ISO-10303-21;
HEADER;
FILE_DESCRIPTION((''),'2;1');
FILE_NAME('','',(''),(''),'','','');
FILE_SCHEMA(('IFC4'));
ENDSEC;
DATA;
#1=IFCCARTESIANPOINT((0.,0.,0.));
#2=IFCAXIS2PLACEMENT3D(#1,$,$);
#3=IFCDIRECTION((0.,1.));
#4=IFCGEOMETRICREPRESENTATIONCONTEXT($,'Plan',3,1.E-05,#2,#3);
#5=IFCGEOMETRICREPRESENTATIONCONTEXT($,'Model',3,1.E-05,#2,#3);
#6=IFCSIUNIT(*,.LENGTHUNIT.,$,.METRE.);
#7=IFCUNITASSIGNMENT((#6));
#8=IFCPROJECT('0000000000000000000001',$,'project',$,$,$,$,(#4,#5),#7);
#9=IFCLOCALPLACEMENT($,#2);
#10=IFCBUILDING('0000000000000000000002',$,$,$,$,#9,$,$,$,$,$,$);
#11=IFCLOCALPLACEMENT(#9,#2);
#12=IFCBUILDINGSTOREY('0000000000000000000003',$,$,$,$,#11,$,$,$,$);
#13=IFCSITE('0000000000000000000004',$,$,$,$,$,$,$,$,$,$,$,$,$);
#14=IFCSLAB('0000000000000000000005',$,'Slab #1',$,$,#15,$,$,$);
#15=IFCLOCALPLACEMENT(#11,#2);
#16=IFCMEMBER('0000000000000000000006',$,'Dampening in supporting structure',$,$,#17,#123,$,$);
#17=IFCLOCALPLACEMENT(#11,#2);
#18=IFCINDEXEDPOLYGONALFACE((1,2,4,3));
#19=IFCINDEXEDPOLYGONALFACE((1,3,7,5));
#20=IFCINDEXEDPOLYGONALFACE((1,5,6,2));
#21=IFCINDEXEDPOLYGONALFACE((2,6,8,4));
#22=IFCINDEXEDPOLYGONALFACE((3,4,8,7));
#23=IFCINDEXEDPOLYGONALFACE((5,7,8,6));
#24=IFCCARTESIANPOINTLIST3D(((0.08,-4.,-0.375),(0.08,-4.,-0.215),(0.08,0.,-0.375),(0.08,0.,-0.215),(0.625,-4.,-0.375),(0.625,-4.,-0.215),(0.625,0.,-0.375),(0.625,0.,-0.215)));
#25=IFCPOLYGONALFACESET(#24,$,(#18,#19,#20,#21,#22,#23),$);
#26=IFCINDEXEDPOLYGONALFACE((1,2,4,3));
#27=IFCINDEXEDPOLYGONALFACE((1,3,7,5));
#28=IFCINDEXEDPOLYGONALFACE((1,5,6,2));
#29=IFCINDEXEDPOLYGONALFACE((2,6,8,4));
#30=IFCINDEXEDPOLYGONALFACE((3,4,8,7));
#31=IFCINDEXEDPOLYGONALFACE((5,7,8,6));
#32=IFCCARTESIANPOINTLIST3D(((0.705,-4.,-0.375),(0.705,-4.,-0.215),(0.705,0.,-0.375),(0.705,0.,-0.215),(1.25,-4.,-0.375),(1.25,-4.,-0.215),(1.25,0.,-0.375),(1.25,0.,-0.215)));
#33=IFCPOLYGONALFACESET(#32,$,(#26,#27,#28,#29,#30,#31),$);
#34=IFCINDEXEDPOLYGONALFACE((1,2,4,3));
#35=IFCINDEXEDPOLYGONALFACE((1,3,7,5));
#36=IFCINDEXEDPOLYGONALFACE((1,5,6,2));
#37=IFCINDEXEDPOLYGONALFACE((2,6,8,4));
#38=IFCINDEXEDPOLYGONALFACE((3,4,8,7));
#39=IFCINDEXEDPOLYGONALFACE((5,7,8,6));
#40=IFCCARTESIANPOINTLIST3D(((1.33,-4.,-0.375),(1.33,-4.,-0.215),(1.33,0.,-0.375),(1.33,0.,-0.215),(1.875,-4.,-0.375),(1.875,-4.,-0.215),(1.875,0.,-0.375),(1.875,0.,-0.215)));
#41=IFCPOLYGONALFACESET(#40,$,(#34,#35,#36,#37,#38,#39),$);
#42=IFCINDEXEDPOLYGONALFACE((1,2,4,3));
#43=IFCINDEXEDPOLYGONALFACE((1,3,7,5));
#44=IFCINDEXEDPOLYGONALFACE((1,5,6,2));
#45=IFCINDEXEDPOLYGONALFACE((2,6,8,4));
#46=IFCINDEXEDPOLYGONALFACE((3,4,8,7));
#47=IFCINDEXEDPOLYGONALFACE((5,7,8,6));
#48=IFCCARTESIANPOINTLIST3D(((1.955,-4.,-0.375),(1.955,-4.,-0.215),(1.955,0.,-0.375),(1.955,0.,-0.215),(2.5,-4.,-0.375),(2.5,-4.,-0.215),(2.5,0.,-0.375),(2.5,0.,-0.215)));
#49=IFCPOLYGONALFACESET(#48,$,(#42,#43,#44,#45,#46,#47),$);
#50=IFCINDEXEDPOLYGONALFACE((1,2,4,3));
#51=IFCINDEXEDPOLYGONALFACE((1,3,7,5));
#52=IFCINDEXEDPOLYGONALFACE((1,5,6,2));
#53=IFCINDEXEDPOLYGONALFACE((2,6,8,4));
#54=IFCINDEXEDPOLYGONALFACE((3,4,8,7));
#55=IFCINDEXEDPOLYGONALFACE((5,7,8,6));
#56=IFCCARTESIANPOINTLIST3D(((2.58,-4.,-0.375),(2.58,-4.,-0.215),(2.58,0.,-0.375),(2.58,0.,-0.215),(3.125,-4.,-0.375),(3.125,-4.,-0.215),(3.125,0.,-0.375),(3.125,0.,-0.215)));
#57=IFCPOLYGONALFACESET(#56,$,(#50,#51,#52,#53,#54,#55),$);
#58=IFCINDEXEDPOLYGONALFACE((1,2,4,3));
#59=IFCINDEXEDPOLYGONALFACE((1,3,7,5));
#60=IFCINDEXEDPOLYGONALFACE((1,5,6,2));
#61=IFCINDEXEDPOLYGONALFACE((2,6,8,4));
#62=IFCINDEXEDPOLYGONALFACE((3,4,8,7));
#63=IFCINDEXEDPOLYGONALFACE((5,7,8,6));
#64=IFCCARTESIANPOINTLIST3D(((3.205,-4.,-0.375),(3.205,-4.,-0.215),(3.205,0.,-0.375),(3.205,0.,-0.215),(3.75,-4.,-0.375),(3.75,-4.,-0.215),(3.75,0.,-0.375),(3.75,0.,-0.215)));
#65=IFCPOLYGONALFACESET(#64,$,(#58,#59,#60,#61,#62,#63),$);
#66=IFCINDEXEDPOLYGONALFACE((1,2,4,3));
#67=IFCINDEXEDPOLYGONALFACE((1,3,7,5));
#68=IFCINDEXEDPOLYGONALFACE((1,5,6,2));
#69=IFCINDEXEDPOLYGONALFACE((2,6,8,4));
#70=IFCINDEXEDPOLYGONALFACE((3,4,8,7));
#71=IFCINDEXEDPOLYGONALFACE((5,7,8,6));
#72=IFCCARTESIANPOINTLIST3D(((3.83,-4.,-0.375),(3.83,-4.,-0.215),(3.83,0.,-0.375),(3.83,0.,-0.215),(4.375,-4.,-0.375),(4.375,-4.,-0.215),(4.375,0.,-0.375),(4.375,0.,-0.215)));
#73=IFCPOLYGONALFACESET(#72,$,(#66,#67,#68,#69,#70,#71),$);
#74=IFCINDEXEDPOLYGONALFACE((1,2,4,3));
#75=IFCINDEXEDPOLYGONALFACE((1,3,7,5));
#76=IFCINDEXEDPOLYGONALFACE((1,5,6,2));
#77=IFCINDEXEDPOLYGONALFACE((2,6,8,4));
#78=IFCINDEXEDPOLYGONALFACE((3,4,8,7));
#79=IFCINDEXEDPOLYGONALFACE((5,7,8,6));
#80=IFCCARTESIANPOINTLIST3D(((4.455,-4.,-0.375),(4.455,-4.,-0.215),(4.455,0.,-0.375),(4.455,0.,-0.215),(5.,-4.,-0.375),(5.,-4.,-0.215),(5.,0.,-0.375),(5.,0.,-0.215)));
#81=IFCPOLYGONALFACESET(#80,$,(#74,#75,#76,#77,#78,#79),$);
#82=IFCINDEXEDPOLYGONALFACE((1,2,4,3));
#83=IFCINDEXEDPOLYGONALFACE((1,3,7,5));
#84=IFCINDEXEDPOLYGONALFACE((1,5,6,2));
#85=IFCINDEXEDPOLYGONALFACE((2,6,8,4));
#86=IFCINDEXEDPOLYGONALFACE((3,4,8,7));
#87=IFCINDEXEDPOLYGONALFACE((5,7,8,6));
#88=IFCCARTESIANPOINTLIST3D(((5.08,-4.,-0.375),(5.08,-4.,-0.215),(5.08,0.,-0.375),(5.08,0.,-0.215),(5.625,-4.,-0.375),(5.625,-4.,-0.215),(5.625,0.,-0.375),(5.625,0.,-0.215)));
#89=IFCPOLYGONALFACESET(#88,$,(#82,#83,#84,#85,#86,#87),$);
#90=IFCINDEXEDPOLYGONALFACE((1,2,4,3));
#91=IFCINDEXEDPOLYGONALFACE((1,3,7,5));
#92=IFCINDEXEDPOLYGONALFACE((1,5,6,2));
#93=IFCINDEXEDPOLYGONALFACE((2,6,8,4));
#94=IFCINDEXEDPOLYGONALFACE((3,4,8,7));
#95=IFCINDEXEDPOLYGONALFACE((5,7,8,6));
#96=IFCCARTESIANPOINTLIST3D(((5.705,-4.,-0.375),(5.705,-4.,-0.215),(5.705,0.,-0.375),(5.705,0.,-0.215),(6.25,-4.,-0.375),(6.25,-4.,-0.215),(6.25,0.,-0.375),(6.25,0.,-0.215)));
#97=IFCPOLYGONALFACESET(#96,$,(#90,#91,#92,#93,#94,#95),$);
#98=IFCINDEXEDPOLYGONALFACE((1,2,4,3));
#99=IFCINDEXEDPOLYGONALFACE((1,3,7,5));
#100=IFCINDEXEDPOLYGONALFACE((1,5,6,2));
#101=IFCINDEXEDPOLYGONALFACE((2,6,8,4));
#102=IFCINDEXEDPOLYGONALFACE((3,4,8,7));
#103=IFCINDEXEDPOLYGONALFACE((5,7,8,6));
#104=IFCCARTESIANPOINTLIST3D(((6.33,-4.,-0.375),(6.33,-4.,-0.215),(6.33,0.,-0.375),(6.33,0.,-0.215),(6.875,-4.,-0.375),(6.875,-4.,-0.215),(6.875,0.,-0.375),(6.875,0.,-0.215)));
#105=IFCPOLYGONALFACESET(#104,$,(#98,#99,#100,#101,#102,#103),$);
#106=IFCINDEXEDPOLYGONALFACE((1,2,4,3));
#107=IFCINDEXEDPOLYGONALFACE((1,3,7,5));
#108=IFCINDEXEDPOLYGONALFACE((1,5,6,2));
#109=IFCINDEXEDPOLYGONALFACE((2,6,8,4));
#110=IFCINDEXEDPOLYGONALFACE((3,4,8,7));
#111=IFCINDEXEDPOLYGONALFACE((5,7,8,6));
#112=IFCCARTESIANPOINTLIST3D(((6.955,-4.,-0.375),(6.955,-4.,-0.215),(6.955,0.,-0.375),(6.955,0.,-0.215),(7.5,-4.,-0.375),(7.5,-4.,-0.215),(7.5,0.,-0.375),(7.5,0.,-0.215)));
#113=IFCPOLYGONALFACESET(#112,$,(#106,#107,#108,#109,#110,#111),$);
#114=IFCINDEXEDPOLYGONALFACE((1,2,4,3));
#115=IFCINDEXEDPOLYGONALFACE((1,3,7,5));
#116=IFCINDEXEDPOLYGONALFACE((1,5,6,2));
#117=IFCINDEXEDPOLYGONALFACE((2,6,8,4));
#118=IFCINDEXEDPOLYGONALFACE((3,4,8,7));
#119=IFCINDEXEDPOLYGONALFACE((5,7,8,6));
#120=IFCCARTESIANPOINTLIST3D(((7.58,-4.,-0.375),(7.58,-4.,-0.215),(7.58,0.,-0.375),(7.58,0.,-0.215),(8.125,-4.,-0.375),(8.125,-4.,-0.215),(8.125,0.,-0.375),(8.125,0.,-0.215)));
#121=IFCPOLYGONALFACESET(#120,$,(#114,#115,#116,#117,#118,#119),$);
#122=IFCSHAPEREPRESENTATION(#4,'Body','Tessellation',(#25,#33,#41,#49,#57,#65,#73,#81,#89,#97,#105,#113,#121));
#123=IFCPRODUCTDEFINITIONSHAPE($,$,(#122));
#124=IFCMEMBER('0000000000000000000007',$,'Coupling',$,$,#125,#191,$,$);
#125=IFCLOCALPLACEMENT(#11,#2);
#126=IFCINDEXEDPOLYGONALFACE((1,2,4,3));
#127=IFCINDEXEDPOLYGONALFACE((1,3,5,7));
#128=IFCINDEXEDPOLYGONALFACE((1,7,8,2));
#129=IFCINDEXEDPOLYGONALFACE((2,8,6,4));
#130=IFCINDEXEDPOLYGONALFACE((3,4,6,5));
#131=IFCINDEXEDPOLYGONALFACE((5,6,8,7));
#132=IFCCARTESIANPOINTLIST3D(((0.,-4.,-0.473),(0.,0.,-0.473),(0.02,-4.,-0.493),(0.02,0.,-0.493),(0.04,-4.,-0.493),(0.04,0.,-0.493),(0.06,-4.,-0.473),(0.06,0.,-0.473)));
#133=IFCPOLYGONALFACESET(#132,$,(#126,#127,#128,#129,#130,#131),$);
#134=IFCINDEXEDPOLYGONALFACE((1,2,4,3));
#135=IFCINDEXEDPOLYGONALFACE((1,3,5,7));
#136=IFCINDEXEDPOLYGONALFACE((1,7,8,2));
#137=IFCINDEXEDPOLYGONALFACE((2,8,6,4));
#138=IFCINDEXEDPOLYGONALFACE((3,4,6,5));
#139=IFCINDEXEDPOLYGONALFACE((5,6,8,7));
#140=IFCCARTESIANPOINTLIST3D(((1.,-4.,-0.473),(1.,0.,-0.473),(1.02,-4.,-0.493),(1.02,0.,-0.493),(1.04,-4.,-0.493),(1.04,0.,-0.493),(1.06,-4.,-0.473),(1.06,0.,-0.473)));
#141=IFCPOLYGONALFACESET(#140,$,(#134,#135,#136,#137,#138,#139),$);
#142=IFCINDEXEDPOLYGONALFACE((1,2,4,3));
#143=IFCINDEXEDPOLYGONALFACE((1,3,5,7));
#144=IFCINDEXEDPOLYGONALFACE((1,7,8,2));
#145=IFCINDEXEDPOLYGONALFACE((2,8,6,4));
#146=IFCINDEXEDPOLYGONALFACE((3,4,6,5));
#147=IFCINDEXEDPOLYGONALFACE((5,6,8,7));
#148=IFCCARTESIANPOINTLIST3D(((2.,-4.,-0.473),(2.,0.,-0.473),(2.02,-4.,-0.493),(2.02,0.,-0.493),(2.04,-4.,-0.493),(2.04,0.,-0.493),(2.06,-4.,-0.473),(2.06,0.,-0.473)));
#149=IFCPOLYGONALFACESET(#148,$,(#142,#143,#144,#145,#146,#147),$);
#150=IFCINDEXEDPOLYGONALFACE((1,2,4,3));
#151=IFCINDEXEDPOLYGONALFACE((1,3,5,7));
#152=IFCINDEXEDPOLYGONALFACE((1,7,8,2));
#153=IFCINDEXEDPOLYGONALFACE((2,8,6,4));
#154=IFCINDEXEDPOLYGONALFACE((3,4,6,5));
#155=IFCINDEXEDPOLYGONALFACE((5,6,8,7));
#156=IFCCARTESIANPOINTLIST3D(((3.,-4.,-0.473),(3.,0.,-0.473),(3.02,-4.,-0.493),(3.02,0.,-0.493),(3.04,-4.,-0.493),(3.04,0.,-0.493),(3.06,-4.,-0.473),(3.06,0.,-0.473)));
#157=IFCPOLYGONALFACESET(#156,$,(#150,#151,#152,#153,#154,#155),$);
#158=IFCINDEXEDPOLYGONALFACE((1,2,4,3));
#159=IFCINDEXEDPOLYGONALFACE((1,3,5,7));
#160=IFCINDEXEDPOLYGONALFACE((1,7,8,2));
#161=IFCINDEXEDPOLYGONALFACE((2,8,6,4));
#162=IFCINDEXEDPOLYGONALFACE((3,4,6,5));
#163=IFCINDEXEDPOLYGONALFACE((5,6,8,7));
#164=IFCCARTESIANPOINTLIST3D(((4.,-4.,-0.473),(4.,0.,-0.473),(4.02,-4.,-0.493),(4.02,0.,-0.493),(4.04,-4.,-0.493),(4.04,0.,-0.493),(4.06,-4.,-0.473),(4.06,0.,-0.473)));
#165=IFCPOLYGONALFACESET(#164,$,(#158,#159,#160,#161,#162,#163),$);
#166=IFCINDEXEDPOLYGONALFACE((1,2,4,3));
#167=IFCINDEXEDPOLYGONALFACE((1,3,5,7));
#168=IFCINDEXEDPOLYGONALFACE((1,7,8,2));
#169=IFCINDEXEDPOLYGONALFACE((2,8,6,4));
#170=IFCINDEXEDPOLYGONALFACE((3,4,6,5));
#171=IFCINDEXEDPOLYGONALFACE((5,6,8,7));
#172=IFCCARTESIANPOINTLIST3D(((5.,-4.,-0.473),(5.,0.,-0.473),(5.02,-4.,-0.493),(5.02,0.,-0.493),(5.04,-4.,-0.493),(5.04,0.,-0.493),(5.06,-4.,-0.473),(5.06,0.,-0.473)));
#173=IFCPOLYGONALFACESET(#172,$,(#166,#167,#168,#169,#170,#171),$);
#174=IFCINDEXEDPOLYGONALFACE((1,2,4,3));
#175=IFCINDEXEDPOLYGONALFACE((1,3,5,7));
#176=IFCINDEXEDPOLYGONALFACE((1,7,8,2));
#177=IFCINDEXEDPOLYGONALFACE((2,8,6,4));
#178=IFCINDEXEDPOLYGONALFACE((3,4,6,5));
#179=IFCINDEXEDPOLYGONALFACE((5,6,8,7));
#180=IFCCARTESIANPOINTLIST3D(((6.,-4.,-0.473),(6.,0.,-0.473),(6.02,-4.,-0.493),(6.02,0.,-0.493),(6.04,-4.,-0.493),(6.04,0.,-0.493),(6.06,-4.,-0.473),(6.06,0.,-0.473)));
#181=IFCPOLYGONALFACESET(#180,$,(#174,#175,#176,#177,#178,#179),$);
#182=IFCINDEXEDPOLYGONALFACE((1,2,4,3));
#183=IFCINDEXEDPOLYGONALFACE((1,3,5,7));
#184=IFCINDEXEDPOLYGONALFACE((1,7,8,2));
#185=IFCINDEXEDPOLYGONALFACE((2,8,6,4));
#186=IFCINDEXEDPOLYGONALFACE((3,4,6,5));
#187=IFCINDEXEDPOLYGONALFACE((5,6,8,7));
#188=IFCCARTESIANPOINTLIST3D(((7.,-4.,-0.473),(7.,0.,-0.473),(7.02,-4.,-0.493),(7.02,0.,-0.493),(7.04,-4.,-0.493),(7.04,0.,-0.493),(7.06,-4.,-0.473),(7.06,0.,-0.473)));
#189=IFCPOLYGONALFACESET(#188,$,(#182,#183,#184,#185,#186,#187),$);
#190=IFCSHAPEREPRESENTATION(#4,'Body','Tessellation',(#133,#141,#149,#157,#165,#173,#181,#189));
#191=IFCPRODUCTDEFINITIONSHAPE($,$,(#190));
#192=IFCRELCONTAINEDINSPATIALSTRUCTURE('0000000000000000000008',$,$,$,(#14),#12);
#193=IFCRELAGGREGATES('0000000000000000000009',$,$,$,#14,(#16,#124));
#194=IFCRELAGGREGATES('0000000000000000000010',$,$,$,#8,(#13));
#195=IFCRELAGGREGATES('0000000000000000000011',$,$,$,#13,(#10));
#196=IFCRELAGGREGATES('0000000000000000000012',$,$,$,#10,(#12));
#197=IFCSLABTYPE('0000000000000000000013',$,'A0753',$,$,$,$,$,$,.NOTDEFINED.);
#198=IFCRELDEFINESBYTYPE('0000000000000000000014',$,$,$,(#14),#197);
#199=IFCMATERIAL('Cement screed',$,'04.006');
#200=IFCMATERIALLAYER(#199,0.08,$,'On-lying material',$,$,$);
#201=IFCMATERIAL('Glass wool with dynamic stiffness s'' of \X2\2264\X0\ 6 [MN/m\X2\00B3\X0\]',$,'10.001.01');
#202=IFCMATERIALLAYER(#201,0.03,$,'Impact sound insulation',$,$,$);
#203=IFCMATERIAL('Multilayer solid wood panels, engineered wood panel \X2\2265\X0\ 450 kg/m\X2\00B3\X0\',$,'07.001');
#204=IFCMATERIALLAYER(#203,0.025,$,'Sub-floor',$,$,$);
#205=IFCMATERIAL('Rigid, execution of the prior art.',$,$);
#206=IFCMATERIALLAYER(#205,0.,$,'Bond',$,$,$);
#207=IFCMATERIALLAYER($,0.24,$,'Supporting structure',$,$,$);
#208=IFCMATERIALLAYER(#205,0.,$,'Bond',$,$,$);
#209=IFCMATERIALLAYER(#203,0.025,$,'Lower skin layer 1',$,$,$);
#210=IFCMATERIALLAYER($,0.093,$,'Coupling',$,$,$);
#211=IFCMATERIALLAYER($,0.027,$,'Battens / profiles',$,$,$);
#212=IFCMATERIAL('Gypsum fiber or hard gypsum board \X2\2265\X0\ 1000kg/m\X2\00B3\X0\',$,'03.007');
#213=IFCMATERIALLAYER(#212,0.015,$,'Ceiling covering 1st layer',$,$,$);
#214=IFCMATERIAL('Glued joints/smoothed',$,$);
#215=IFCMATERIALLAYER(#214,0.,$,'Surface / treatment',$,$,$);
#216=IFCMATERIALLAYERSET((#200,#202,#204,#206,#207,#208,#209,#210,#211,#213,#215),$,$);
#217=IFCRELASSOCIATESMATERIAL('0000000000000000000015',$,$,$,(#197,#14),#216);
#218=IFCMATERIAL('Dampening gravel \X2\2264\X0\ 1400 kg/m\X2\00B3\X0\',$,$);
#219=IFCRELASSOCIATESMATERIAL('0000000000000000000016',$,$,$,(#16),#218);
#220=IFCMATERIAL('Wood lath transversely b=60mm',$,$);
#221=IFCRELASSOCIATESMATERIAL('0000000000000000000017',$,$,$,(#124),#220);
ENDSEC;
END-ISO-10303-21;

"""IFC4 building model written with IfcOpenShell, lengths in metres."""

from ifc_helpers import new_model, si_unit, direction, frame, frame_2d, origin, place, context, project, spatial, polyline, rectangle, outline, extrude, material, layer, layer_set, type_object, element, aggregate, save


model = new_model("IFC4")

# Units and contexts
plan_context = context("Plan", 3, precision=1e-05, world=origin(), true_north=direction((0.0, 1.0)))
model_context = context("Model", 3, precision=1e-05, world=origin(), true_north=direction((0.0, 1.0)))
ifc_project = project(units=[si_unit("LENGTHUNIT", "METRE")], contexts=[plan_context, model_context])

# Site, building, storey
site = spatial("IfcSite", under=ifc_project)
building_placement = place(None, origin())
building = spatial("IfcBuilding", under=site, at=building_placement)
storey_placement = place(building_placement, origin())
storey = spatial("IfcBuildingStorey", under=building, at=storey_placement)

# Slab, members
ifc_material_1 = material(Name="Cement screed", Category="04.006")
ifc_layer_1 = layer(ifc_material_1, 0.08, Name="On-lying material")
ifc_material_2 = material(Name="Glass wool with dynamic stiffness s' of ≤ 6 [MN/m³]", Category="10.001.01")
ifc_layer_2 = layer(ifc_material_2, 0.03, Name="Impact sound insulation")
ifc_material_3 = material(Name="Multilayer solid wood panels, engineered wood panel ≥ 450 kg/m³", Category="07.001")
ifc_layer_3 = layer(ifc_material_3, 0.025, Name="Sub-floor")
ifc_material_4 = material(Name="Rigid, execution of the prior art.")
ifc_layer_4 = layer(ifc_material_4, 0.0, Name="Bond")
ifc_layer_5 = layer(None, 0.24, Name="Supporting structure")
ifc_layer_6 = layer(ifc_material_4, 0.0, Name="Bond")
ifc_layer_7 = layer(ifc_material_3, 0.025, Name="Lower skin layer 1")
ifc_layer_8 = layer(None, 0.093, Name="Coupling")
ifc_layer_9 = layer(None, 0.027, Name="Battens / profiles")
ifc_material_5 = material(Name="Gypsum fiber or hard gypsum board ≥ 1000kg/m³", Category="03.007")
ifc_layer_10 = layer(ifc_material_5, 0.015, Name="Ceiling covering 1st layer")
ifc_material_6 = material(Name="Glued joints/smoothed")
ifc_layer_11 = layer(ifc_material_6, 0.0, Name="Surface / treatment")
ifc_layer_set = layer_set([ifc_layer_1, ifc_layer_2, ifc_layer_3, ifc_layer_4, ifc_layer_5, ifc_layer_6, ifc_layer_7, ifc_layer_8, ifc_layer_9, ifc_layer_10, ifc_layer_11])
slab_type = type_object("IfcSlabType", Name="A0753", PredefinedType="NOTDEFINED", material=ifc_layer_set)
slab_placement = place(None, frame((0.0, 0.0, 0.0), z_axis=(0.0, 0.0, -1.0), x_axis=(1.0, 0.0, 0.0)))
slab = element("IfcSlab", 1, at=slab_placement, inside=storey, type_object=slab_type, material=ifc_layer_set, Name="Slab #1")
ifc_material_7 = material(Name="Dampening gravel ≤ 1400 kg/m³")
member_1_placement = place(slab_placement, origin())
member_1 = element("IfcMember", 2, at=member_1_placement, material=ifc_material_7, Name="Dampening in supporting structure", context=plan_context, shape_type="SweptSolid", body=[
    extrude(rectangle(XDim=0.545, YDim=0.16, at=frame_2d((0.2725, 0.08), x_axis=(1.0, 0.0))), frame((0.08, 4.0, 0.215), z_axis=(0.0, -1.0, 0.0), x_axis=(1.0, 0.0, 0.0)), (0.0, 0.0, 1.0), 4.0),
    extrude(rectangle(XDim=0.545, YDim=0.16, at=frame_2d((0.2725, 0.08), x_axis=(1.0, 0.0))), frame((0.705, 4.0, 0.215), z_axis=(0.0, -1.0, 0.0), x_axis=(1.0, 0.0, 0.0)), (0.0, 0.0, 1.0), 4.0),
    extrude(rectangle(XDim=0.545, YDim=0.16, at=frame_2d((0.2725, 0.08), x_axis=(1.0, 0.0))), frame((1.33, 4.0, 0.215), z_axis=(0.0, -1.0, 0.0), x_axis=(1.0, 0.0, 0.0)), (0.0, 0.0, 1.0), 4.0),
    extrude(rectangle(XDim=0.545, YDim=0.16, at=frame_2d((0.2725, 0.08), x_axis=(1.0, 0.0))), frame((1.955, 4.0, 0.215), z_axis=(0.0, -1.0, 0.0), x_axis=(1.0, 0.0, 0.0)), (0.0, 0.0, 1.0), 4.0),
    extrude(rectangle(XDim=0.545, YDim=0.16, at=frame_2d((0.2725, 0.08), x_axis=(1.0, 0.0))), frame((2.58, 4.0, 0.215), z_axis=(0.0, -1.0, 0.0), x_axis=(1.0, 0.0, 0.0)), (0.0, 0.0, 1.0), 4.0),
    extrude(rectangle(XDim=0.545, YDim=0.16, at=frame_2d((0.2725, 0.08), x_axis=(1.0, 0.0))), frame((3.205, 4.0, 0.215), z_axis=(0.0, -1.0, 0.0), x_axis=(1.0, 0.0, 0.0)), (0.0, 0.0, 1.0), 4.0),
    extrude(rectangle(XDim=0.545, YDim=0.16, at=frame_2d((0.2725, 0.08), x_axis=(1.0, 0.0))), frame((3.83, 4.0, 0.215), z_axis=(0.0, -1.0, 0.0), x_axis=(1.0, 0.0, 0.0)), (0.0, 0.0, 1.0), 4.0),
    extrude(rectangle(XDim=0.545, YDim=0.16, at=frame_2d((0.2725, 0.08), x_axis=(1.0, 0.0))), frame((4.455, 4.0, 0.215), z_axis=(0.0, -1.0, 0.0), x_axis=(1.0, 0.0, 0.0)), (0.0, 0.0, 1.0), 4.0),
    extrude(rectangle(XDim=0.545, YDim=0.16, at=frame_2d((0.2725, 0.08), x_axis=(1.0, 0.0))), frame((5.08, 4.0, 0.215), z_axis=(0.0, -1.0, 0.0), x_axis=(1.0, 0.0, 0.0)), (0.0, 0.0, 1.0), 4.0),
    extrude(rectangle(XDim=0.545, YDim=0.16, at=frame_2d((0.2725, 0.08), x_axis=(1.0, 0.0))), frame((5.705, 4.0, 0.215), z_axis=(0.0, -1.0, 0.0), x_axis=(1.0, 0.0, 0.0)), (0.0, 0.0, 1.0), 4.0),
    extrude(rectangle(XDim=0.545, YDim=0.16, at=frame_2d((0.2725, 0.08), x_axis=(1.0, 0.0))), frame((6.33, 4.0, 0.215), z_axis=(0.0, -1.0, 0.0), x_axis=(1.0, 0.0, 0.0)), (0.0, 0.0, 1.0), 4.0),
    extrude(rectangle(XDim=0.545, YDim=0.16, at=frame_2d((0.2725, 0.08), x_axis=(1.0, 0.0))), frame((6.955, 4.0, 0.215), z_axis=(0.0, -1.0, 0.0), x_axis=(1.0, 0.0, 0.0)), (0.0, 0.0, 1.0), 4.0),
    extrude(rectangle(XDim=0.545, YDim=0.16, at=frame_2d((0.2725, 0.08), x_axis=(1.0, 0.0))), frame((7.58, 4.0, 0.215), z_axis=(0.0, -1.0, 0.0), x_axis=(1.0, 0.0, 0.0)), (0.0, 0.0, 1.0), 4.0),
])
ifc_material_8 = material(Name="Wood lath transversely b=60mm")
member_2_placement = place(slab_placement, origin())
member_2 = element("IfcMember", 3, at=member_2_placement, material=ifc_material_8, Name="Coupling", context=plan_context, shape_type="SweptSolid", body=[
    extrude(outline(polyline([(0.0, 0.0), (0.06, 0.0), (0.04, 0.02), (0.02, 0.02), (0.0, 0.0)])), frame((0.0, 4.0, 0.473), z_axis=(0.0, -1.0, 0.0), x_axis=(1.0, 0.0, 0.0)), (0.0, 0.0, 1.0), 4.0),
    extrude(outline(polyline([(0.0, 0.0), (0.06, 0.0), (0.04, 0.02), (0.02, 0.02), (0.0, 0.0)])), frame((1.0, 4.0, 0.473), z_axis=(0.0, -1.0, 0.0), x_axis=(1.0, 0.0, 0.0)), (0.0, 0.0, 1.0), 4.0),
    extrude(outline(polyline([(0.0, 0.0), (0.06, 0.0), (0.04, 0.02), (0.02, 0.02), (0.0, 0.0)])), frame((2.0, 4.0, 0.473), z_axis=(0.0, -1.0, 0.0), x_axis=(1.0, 0.0, 0.0)), (0.0, 0.0, 1.0), 4.0),
    extrude(outline(polyline([(0.0, 0.0), (0.06, 0.0), (0.04, 0.02), (0.02, 0.02), (0.0, 0.0)])), frame((3.0, 4.0, 0.473), z_axis=(0.0, -1.0, 0.0), x_axis=(1.0, 0.0, 0.0)), (0.0, 0.0, 1.0), 4.0),
    extrude(outline(polyline([(0.0, 0.0), (0.06, 0.0), (0.04, 0.02), (0.02, 0.02), (0.0, 0.0)])), frame((4.0, 4.0, 0.473), z_axis=(0.0, -1.0, 0.0), x_axis=(1.0, 0.0, 0.0)), (0.0, 0.0, 1.0), 4.0),
    extrude(outline(polyline([(0.0, 0.0), (0.06, 0.0), (0.04, 0.02), (0.02, 0.02), (0.0, 0.0)])), frame((5.0, 4.0, 0.473), z_axis=(0.0, -1.0, 0.0), x_axis=(1.0, 0.0, 0.0)), (0.0, 0.0, 1.0), 4.0),
    extrude(outline(polyline([(0.0, 0.0), (0.06, 0.0), (0.04, 0.02), (0.02, 0.02), (0.0, 0.0)])), frame((6.0, 4.0, 0.473), z_axis=(0.0, -1.0, 0.0), x_axis=(1.0, 0.0, 0.0)), (0.0, 0.0, 1.0), 4.0),
    extrude(outline(polyline([(0.0, 0.0), (0.06, 0.0), (0.04, 0.02), (0.02, 0.02), (0.0, 0.0)])), frame((7.0, 4.0, 0.473), z_axis=(0.0, -1.0, 0.0), x_axis=(1.0, 0.0, 0.0)), (0.0, 0.0, 1.0), 4.0),
])
aggregate(slab, [member_1, member_2])

save(model, "model.ifc")
